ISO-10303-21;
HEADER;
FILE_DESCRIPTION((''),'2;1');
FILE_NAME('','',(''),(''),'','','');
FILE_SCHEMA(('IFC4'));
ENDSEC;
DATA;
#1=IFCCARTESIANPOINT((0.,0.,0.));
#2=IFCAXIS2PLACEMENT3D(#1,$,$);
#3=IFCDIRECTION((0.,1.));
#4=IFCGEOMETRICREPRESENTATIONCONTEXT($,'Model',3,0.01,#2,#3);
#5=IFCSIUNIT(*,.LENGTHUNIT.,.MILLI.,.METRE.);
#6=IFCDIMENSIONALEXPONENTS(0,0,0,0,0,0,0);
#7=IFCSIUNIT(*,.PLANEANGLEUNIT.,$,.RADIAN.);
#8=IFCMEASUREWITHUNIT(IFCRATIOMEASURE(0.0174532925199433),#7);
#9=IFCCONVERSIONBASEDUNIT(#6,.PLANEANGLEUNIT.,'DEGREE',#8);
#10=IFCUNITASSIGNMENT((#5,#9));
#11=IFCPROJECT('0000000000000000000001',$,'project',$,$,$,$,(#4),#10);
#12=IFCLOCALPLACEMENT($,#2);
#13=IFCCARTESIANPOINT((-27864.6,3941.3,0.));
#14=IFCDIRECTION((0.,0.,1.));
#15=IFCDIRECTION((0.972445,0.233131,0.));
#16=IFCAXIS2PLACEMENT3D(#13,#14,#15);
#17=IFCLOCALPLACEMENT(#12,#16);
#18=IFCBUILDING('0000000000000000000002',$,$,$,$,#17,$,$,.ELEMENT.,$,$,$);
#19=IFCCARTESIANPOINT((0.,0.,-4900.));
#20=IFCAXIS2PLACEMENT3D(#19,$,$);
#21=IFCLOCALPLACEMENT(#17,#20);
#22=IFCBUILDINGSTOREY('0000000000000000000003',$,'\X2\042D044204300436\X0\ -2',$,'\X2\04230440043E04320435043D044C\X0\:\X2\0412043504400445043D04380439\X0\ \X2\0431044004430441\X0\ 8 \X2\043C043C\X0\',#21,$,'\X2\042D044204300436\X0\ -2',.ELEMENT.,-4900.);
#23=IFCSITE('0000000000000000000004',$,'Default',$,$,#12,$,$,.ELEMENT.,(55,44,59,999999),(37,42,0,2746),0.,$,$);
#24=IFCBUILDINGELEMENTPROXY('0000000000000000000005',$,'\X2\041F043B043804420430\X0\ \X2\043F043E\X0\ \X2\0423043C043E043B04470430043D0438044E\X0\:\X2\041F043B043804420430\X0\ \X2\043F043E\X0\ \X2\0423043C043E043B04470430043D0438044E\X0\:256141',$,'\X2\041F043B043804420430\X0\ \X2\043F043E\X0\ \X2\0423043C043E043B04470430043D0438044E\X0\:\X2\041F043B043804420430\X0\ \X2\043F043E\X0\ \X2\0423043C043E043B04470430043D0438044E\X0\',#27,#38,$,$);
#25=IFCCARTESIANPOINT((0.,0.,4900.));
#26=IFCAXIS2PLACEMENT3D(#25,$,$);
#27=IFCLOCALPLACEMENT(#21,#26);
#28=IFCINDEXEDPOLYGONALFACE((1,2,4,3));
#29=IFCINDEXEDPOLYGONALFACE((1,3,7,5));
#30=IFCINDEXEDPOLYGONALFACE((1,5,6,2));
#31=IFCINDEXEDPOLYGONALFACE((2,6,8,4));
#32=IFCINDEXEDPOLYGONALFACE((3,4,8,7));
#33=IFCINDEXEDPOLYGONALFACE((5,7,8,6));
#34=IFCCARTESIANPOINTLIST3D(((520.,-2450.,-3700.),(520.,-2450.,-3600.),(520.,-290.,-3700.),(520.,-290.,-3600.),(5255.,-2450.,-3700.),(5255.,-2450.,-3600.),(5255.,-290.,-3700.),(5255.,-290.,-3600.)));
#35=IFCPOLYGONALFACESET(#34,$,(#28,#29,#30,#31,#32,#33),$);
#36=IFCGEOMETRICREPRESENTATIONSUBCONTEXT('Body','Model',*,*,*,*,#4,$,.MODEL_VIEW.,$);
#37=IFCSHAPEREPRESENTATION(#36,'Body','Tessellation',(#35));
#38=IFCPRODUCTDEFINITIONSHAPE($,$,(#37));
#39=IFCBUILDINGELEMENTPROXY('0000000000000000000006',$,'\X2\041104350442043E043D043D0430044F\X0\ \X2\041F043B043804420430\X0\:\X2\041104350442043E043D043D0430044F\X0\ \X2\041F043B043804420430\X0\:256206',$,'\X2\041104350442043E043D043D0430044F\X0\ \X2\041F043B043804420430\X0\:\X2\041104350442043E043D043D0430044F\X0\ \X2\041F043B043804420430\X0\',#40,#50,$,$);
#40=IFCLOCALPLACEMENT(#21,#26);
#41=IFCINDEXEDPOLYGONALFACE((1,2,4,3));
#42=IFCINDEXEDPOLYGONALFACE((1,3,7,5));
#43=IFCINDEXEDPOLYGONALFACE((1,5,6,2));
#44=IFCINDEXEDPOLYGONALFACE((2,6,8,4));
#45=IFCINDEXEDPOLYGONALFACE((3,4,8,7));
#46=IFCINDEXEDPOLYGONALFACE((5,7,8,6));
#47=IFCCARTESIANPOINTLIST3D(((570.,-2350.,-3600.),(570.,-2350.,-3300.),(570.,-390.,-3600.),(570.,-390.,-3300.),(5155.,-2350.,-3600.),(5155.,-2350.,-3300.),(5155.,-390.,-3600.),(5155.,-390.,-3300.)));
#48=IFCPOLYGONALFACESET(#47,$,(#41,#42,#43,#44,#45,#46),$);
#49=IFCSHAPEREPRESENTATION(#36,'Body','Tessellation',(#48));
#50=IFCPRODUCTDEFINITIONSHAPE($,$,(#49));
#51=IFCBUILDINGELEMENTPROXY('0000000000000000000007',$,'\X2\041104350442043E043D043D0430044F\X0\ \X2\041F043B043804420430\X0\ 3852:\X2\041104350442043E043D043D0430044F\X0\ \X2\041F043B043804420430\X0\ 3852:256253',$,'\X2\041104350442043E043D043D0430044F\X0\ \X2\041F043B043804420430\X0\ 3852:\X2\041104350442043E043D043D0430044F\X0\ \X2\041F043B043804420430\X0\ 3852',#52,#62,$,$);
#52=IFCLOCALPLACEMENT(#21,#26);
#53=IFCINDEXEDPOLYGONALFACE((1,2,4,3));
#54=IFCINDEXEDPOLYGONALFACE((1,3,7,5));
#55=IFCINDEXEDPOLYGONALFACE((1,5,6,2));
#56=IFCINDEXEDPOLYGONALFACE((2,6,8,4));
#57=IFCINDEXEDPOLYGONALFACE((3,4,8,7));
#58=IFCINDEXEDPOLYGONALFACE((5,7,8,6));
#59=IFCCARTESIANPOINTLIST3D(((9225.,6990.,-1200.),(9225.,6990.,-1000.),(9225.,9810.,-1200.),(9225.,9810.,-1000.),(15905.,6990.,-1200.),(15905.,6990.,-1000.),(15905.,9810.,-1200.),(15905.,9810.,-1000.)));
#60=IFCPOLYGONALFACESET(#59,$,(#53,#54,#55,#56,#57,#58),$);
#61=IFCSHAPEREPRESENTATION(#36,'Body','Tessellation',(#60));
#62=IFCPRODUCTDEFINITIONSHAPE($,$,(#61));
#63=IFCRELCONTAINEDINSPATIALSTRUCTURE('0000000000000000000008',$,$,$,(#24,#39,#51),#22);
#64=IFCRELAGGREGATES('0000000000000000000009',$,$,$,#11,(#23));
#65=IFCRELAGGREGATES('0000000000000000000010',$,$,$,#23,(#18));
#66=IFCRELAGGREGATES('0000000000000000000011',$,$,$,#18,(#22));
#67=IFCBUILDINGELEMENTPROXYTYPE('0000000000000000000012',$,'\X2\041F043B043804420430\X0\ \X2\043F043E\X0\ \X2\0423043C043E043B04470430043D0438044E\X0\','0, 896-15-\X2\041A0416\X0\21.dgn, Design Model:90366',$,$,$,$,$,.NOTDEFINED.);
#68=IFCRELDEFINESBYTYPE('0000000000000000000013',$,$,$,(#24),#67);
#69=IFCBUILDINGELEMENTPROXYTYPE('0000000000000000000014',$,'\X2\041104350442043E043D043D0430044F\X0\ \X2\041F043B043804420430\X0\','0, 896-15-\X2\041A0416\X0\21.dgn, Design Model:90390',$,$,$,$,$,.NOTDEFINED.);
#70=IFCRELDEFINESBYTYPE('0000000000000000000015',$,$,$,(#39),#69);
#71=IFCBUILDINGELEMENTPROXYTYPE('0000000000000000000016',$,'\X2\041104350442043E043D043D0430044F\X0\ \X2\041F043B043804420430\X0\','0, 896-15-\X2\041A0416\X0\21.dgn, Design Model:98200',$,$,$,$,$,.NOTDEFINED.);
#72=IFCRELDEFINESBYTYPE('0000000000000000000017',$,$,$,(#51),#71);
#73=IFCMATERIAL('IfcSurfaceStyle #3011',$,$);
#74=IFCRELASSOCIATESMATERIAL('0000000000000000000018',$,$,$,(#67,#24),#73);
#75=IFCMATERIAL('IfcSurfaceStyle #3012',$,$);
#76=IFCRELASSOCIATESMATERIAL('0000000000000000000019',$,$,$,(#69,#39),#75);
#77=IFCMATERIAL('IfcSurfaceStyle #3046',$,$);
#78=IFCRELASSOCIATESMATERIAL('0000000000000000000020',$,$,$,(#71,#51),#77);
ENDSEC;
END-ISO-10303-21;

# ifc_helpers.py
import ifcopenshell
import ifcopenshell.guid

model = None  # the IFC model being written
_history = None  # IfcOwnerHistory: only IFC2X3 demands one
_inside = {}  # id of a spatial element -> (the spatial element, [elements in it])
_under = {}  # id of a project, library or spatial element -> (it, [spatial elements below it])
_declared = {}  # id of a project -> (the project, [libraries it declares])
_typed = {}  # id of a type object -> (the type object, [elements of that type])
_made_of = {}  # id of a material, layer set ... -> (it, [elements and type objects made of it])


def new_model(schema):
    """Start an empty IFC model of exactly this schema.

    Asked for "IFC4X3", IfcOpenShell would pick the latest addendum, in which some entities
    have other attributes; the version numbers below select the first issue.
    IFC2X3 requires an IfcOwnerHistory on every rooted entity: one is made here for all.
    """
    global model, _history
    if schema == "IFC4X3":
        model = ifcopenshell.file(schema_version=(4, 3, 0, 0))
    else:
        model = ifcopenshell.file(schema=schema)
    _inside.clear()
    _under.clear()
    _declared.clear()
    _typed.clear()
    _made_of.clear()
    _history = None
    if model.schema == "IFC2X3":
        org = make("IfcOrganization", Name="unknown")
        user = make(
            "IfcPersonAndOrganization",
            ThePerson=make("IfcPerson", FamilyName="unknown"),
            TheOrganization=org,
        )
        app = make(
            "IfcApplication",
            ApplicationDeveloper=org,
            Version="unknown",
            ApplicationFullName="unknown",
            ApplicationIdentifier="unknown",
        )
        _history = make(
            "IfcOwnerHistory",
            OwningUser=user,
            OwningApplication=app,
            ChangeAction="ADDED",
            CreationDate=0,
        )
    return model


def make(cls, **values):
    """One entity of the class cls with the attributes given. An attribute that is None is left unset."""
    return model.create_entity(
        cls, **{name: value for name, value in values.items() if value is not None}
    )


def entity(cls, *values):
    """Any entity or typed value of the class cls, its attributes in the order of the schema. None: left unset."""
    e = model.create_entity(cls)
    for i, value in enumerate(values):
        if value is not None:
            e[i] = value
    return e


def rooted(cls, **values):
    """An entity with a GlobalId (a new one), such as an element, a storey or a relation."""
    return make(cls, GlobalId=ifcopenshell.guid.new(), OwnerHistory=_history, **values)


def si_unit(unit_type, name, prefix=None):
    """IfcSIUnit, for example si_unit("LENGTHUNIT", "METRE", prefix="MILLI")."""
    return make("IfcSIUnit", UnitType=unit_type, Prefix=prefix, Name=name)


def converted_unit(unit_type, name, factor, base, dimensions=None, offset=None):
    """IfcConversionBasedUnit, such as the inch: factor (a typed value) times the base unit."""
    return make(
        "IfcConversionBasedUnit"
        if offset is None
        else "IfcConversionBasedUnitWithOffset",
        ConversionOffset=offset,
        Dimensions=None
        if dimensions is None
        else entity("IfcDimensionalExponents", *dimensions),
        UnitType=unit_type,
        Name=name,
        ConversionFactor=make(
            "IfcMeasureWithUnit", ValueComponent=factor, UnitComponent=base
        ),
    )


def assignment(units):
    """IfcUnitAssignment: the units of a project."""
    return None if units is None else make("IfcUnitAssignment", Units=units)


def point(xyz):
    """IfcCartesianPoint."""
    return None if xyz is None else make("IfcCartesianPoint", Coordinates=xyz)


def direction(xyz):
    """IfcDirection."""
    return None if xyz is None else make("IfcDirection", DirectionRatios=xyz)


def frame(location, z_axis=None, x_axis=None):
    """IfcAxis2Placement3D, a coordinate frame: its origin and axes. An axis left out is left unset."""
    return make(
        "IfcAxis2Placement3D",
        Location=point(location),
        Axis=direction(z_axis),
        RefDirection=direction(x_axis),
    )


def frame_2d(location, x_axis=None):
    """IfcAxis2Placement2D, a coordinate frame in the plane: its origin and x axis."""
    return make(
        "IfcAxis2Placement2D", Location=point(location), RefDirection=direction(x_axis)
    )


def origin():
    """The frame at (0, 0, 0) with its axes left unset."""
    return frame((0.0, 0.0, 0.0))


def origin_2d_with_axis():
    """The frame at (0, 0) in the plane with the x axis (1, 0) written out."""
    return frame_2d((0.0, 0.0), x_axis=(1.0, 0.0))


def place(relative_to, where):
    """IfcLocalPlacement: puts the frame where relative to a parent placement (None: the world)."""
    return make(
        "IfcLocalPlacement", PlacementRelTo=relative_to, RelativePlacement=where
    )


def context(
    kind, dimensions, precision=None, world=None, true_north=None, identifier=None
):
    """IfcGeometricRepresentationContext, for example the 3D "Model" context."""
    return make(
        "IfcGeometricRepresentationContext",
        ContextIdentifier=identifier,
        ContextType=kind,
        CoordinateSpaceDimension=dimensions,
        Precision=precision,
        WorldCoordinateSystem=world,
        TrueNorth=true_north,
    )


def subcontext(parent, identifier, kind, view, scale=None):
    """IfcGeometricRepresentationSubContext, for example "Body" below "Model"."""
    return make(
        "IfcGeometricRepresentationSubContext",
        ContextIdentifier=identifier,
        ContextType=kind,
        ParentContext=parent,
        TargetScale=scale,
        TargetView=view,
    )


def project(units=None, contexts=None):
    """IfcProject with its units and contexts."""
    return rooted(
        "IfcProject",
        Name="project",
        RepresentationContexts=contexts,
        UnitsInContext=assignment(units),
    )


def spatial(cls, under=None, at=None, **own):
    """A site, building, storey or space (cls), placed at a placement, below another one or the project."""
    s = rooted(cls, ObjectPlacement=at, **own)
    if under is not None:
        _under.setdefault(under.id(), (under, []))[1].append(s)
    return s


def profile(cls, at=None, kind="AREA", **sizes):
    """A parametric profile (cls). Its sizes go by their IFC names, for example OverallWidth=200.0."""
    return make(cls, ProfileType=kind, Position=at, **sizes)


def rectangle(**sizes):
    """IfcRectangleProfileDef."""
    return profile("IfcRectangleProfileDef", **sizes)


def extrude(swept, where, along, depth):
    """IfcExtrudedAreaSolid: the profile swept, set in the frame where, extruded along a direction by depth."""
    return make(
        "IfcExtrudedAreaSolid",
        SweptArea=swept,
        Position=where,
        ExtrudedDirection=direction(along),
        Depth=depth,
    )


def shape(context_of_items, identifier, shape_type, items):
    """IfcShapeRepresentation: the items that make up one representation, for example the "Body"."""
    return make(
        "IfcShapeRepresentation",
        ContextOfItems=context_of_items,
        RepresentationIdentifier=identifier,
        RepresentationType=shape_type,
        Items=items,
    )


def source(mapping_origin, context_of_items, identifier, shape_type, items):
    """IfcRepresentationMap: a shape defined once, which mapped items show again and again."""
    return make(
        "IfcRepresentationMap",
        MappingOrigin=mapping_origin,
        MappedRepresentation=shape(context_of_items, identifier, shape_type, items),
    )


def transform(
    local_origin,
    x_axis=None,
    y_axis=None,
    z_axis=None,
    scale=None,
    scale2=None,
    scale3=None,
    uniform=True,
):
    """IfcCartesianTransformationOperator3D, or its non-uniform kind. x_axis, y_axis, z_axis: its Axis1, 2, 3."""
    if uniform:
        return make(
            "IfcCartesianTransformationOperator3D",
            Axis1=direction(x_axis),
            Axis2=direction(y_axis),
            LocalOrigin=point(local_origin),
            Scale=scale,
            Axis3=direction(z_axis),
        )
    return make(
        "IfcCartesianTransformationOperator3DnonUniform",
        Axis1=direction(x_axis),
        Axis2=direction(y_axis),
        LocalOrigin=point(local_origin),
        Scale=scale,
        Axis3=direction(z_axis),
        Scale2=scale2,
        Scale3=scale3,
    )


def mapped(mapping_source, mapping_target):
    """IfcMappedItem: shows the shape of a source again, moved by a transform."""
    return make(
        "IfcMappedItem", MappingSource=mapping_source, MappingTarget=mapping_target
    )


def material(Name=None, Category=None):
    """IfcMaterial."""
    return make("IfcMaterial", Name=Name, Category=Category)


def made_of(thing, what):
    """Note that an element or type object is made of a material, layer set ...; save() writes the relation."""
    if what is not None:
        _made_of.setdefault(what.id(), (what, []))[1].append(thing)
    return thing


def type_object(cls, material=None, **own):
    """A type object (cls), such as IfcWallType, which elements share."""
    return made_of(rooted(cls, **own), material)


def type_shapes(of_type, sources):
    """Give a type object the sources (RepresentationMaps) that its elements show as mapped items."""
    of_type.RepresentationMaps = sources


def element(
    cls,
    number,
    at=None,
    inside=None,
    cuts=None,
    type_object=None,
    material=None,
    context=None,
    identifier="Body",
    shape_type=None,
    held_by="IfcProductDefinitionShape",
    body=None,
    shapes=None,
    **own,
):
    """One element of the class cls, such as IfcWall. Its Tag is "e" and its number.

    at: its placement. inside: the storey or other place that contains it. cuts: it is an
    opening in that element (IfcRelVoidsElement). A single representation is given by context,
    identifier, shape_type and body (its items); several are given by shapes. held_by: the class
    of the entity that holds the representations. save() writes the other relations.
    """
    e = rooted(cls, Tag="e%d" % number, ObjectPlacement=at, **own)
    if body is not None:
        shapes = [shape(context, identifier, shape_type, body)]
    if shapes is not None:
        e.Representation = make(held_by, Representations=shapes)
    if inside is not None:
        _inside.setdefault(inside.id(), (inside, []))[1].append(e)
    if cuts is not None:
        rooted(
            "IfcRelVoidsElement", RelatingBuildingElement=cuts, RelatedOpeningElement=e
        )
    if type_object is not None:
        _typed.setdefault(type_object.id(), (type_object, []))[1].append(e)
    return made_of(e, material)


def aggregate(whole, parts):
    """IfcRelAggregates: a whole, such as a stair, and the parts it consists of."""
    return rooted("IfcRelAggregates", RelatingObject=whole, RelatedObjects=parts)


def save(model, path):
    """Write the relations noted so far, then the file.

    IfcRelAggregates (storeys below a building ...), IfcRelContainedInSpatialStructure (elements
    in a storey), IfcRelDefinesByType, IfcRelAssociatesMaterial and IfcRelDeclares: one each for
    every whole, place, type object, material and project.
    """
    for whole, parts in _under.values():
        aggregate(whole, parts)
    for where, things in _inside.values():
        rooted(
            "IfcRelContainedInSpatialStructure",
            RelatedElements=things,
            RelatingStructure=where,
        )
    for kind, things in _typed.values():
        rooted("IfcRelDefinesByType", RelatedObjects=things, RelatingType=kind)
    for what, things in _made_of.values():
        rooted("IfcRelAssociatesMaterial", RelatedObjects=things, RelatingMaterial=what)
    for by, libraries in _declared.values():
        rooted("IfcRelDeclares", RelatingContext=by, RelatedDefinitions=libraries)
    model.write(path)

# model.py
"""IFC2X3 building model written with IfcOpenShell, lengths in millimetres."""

from ifc_helpers import new_model, entity, si_unit, converted_unit, direction, frame, frame_2d, origin, origin_2d_with_axis, place, context, subcontext, project, spatial, rectangle, extrude, source, transform, mapped, material, type_object, type_shapes, element, save


model = new_model("IFC2X3")

# Units and contexts
model_context = context("Model", 3, precision=0.01, world=origin(), true_north=direction((0.0, 1.0)))
body_context = subcontext(model_context, "Body", "Model", "MODEL_VIEW")
ifc_project = project(units=[si_unit("LENGTHUNIT", "METRE", prefix="MILLI"), converted_unit("PLANEANGLEUNIT", "DEGREE", entity("IfcRatioMeasure", 0.0174532925199433), si_unit("PLANEANGLEUNIT", "RADIAN"), dimensions=[0, 0, 0, 0, 0, 0, 0])], contexts=[model_context])

# Site, building, storey
site_placement = place(None, origin())
site = spatial("IfcSite", under=ifc_project, at=site_placement, Name="Default", CompositionType="ELEMENT", RefLatitude=(55, 44, 59, 999999), RefLongitude=(37, 42, 0, 2746), RefElevation=0.0)
building_placement = place(site_placement, frame((-27864.6, 3941.3, 0.0), z_axis=(0.0, 0.0, 1.0), x_axis=(0.972445, 0.233131, 0.0)))
building = spatial("IfcBuilding", under=site, at=building_placement, CompositionType="ELEMENT")
storey_placement = place(building_placement, frame((0.0, 0.0, -4900.0)))
storey = spatial("IfcBuildingStorey", under=building, at=storey_placement, Name="Этаж -2", ObjectType="Уровень:Верхний брус 8 мм", LongName="Этаж -2", CompositionType="ELEMENT", Elevation=-4900.0)

# Building element proxies
ifc_material_1 = material(Name="IfcSurfaceStyle #3011")
building_element_proxy_type_1 = type_object("IfcBuildingElementProxyType", Name="Плита по Умолчанию", Description="0, 896-15-КЖ21.dgn, Design Model:90366", PredefinedType="NOTDEFINED", material=ifc_material_1)
shared_shape_1 = source(origin(), body_context, "Body", "SweptSolid", [
    extrude(rectangle(XDim=2160.0, YDim=4735.0, at=origin_2d_with_axis()), frame((2887.5, -1370.0, -3700.0), z_axis=(0.0, 0.0, 1.0), x_axis=(0.0, 1.0, 0.0)), (0.0, 0.0, 1.0), 100.0),
])
type_shapes(building_element_proxy_type_1, [shared_shape_1])
proxy_1_placement = place(storey_placement, frame((0.0, 0.0, 4900.0)))
element("IfcBuildingElementProxy", 1, at=proxy_1_placement, inside=storey, type_object=building_element_proxy_type_1, material=ifc_material_1, Name="Плита по Умолчанию:Плита по Умолчанию:256141", ObjectType="Плита по Умолчанию:Плита по Умолчанию", context=body_context, shape_type="MappedRepresentation", body=[
    mapped(shared_shape_1, transform((0.0, 0.0, 0.0), scale=1.0)),
])
ifc_material_2 = material(Name="IfcSurfaceStyle #3012")
building_element_proxy_type_2 = type_object("IfcBuildingElementProxyType", Name="Бетонная Плита", Description="0, 896-15-КЖ21.dgn, Design Model:90390", PredefinedType="NOTDEFINED", material=ifc_material_2)
shared_shape_2 = source(origin(), body_context, "Body", "SweptSolid", [
    extrude(rectangle(XDim=4585.0, YDim=1960.0, at=frame_2d((0.0, 0.0), x_axis=(1.0, 0.0))), frame((2862.5, -1370.0, -3600.0), z_axis=(0.0, 0.0, 1.0), x_axis=(-1.0, 0.0, 0.0)), (0.0, 0.0, 1.0), 300.0),
])
type_shapes(building_element_proxy_type_2, [shared_shape_2])
proxy_2_placement = place(storey_placement, frame((0.0, 0.0, 4900.0)))
element("IfcBuildingElementProxy", 2, at=proxy_2_placement, inside=storey, type_object=building_element_proxy_type_2, material=ifc_material_2, Name="Бетонная Плита:Бетонная Плита:256206", ObjectType="Бетонная Плита:Бетонная Плита", context=body_context, shape_type="MappedRepresentation", body=[
    mapped(shared_shape_2, transform((0.0, 0.0, 0.0), scale=1.0)),
])
ifc_material_3 = material(Name="IfcSurfaceStyle #3046")
building_element_proxy_type_3 = type_object("IfcBuildingElementProxyType", Name="Бетонная Плита", Description="0, 896-15-КЖ21.dgn, Design Model:98200", PredefinedType="NOTDEFINED", material=ifc_material_3)
shared_shape_3 = source(origin(), body_context, "Body", "SweptSolid", [
    extrude(rectangle(XDim=2820.0, YDim=6680.0, at=frame_2d((0.0, 0.0), x_axis=(1.0, 0.0))), frame((12565.0, 8400.0, -1200.0), z_axis=(0.0, 0.0, 1.0), x_axis=(0.0, 1.0, 0.0)), (0.0, 0.0, 1.0), 200.0),
])
type_shapes(building_element_proxy_type_3, [shared_shape_3])
proxy_3_placement = place(storey_placement, frame((0.0, 0.0, 4900.0)))
element("IfcBuildingElementProxy", 3, at=proxy_3_placement, inside=storey, type_object=building_element_proxy_type_3, material=ifc_material_3, Name="Бетонная Плита 3852:Бетонная Плита 3852:256253", ObjectType="Бетонная Плита 3852:Бетонная Плита 3852", context=body_context, shape_type="MappedRepresentation", body=[
    mapped(shared_shape_3, transform((0.0, 0.0, 0.0), scale=1.0)),
])

save(model, "model.ifc")
